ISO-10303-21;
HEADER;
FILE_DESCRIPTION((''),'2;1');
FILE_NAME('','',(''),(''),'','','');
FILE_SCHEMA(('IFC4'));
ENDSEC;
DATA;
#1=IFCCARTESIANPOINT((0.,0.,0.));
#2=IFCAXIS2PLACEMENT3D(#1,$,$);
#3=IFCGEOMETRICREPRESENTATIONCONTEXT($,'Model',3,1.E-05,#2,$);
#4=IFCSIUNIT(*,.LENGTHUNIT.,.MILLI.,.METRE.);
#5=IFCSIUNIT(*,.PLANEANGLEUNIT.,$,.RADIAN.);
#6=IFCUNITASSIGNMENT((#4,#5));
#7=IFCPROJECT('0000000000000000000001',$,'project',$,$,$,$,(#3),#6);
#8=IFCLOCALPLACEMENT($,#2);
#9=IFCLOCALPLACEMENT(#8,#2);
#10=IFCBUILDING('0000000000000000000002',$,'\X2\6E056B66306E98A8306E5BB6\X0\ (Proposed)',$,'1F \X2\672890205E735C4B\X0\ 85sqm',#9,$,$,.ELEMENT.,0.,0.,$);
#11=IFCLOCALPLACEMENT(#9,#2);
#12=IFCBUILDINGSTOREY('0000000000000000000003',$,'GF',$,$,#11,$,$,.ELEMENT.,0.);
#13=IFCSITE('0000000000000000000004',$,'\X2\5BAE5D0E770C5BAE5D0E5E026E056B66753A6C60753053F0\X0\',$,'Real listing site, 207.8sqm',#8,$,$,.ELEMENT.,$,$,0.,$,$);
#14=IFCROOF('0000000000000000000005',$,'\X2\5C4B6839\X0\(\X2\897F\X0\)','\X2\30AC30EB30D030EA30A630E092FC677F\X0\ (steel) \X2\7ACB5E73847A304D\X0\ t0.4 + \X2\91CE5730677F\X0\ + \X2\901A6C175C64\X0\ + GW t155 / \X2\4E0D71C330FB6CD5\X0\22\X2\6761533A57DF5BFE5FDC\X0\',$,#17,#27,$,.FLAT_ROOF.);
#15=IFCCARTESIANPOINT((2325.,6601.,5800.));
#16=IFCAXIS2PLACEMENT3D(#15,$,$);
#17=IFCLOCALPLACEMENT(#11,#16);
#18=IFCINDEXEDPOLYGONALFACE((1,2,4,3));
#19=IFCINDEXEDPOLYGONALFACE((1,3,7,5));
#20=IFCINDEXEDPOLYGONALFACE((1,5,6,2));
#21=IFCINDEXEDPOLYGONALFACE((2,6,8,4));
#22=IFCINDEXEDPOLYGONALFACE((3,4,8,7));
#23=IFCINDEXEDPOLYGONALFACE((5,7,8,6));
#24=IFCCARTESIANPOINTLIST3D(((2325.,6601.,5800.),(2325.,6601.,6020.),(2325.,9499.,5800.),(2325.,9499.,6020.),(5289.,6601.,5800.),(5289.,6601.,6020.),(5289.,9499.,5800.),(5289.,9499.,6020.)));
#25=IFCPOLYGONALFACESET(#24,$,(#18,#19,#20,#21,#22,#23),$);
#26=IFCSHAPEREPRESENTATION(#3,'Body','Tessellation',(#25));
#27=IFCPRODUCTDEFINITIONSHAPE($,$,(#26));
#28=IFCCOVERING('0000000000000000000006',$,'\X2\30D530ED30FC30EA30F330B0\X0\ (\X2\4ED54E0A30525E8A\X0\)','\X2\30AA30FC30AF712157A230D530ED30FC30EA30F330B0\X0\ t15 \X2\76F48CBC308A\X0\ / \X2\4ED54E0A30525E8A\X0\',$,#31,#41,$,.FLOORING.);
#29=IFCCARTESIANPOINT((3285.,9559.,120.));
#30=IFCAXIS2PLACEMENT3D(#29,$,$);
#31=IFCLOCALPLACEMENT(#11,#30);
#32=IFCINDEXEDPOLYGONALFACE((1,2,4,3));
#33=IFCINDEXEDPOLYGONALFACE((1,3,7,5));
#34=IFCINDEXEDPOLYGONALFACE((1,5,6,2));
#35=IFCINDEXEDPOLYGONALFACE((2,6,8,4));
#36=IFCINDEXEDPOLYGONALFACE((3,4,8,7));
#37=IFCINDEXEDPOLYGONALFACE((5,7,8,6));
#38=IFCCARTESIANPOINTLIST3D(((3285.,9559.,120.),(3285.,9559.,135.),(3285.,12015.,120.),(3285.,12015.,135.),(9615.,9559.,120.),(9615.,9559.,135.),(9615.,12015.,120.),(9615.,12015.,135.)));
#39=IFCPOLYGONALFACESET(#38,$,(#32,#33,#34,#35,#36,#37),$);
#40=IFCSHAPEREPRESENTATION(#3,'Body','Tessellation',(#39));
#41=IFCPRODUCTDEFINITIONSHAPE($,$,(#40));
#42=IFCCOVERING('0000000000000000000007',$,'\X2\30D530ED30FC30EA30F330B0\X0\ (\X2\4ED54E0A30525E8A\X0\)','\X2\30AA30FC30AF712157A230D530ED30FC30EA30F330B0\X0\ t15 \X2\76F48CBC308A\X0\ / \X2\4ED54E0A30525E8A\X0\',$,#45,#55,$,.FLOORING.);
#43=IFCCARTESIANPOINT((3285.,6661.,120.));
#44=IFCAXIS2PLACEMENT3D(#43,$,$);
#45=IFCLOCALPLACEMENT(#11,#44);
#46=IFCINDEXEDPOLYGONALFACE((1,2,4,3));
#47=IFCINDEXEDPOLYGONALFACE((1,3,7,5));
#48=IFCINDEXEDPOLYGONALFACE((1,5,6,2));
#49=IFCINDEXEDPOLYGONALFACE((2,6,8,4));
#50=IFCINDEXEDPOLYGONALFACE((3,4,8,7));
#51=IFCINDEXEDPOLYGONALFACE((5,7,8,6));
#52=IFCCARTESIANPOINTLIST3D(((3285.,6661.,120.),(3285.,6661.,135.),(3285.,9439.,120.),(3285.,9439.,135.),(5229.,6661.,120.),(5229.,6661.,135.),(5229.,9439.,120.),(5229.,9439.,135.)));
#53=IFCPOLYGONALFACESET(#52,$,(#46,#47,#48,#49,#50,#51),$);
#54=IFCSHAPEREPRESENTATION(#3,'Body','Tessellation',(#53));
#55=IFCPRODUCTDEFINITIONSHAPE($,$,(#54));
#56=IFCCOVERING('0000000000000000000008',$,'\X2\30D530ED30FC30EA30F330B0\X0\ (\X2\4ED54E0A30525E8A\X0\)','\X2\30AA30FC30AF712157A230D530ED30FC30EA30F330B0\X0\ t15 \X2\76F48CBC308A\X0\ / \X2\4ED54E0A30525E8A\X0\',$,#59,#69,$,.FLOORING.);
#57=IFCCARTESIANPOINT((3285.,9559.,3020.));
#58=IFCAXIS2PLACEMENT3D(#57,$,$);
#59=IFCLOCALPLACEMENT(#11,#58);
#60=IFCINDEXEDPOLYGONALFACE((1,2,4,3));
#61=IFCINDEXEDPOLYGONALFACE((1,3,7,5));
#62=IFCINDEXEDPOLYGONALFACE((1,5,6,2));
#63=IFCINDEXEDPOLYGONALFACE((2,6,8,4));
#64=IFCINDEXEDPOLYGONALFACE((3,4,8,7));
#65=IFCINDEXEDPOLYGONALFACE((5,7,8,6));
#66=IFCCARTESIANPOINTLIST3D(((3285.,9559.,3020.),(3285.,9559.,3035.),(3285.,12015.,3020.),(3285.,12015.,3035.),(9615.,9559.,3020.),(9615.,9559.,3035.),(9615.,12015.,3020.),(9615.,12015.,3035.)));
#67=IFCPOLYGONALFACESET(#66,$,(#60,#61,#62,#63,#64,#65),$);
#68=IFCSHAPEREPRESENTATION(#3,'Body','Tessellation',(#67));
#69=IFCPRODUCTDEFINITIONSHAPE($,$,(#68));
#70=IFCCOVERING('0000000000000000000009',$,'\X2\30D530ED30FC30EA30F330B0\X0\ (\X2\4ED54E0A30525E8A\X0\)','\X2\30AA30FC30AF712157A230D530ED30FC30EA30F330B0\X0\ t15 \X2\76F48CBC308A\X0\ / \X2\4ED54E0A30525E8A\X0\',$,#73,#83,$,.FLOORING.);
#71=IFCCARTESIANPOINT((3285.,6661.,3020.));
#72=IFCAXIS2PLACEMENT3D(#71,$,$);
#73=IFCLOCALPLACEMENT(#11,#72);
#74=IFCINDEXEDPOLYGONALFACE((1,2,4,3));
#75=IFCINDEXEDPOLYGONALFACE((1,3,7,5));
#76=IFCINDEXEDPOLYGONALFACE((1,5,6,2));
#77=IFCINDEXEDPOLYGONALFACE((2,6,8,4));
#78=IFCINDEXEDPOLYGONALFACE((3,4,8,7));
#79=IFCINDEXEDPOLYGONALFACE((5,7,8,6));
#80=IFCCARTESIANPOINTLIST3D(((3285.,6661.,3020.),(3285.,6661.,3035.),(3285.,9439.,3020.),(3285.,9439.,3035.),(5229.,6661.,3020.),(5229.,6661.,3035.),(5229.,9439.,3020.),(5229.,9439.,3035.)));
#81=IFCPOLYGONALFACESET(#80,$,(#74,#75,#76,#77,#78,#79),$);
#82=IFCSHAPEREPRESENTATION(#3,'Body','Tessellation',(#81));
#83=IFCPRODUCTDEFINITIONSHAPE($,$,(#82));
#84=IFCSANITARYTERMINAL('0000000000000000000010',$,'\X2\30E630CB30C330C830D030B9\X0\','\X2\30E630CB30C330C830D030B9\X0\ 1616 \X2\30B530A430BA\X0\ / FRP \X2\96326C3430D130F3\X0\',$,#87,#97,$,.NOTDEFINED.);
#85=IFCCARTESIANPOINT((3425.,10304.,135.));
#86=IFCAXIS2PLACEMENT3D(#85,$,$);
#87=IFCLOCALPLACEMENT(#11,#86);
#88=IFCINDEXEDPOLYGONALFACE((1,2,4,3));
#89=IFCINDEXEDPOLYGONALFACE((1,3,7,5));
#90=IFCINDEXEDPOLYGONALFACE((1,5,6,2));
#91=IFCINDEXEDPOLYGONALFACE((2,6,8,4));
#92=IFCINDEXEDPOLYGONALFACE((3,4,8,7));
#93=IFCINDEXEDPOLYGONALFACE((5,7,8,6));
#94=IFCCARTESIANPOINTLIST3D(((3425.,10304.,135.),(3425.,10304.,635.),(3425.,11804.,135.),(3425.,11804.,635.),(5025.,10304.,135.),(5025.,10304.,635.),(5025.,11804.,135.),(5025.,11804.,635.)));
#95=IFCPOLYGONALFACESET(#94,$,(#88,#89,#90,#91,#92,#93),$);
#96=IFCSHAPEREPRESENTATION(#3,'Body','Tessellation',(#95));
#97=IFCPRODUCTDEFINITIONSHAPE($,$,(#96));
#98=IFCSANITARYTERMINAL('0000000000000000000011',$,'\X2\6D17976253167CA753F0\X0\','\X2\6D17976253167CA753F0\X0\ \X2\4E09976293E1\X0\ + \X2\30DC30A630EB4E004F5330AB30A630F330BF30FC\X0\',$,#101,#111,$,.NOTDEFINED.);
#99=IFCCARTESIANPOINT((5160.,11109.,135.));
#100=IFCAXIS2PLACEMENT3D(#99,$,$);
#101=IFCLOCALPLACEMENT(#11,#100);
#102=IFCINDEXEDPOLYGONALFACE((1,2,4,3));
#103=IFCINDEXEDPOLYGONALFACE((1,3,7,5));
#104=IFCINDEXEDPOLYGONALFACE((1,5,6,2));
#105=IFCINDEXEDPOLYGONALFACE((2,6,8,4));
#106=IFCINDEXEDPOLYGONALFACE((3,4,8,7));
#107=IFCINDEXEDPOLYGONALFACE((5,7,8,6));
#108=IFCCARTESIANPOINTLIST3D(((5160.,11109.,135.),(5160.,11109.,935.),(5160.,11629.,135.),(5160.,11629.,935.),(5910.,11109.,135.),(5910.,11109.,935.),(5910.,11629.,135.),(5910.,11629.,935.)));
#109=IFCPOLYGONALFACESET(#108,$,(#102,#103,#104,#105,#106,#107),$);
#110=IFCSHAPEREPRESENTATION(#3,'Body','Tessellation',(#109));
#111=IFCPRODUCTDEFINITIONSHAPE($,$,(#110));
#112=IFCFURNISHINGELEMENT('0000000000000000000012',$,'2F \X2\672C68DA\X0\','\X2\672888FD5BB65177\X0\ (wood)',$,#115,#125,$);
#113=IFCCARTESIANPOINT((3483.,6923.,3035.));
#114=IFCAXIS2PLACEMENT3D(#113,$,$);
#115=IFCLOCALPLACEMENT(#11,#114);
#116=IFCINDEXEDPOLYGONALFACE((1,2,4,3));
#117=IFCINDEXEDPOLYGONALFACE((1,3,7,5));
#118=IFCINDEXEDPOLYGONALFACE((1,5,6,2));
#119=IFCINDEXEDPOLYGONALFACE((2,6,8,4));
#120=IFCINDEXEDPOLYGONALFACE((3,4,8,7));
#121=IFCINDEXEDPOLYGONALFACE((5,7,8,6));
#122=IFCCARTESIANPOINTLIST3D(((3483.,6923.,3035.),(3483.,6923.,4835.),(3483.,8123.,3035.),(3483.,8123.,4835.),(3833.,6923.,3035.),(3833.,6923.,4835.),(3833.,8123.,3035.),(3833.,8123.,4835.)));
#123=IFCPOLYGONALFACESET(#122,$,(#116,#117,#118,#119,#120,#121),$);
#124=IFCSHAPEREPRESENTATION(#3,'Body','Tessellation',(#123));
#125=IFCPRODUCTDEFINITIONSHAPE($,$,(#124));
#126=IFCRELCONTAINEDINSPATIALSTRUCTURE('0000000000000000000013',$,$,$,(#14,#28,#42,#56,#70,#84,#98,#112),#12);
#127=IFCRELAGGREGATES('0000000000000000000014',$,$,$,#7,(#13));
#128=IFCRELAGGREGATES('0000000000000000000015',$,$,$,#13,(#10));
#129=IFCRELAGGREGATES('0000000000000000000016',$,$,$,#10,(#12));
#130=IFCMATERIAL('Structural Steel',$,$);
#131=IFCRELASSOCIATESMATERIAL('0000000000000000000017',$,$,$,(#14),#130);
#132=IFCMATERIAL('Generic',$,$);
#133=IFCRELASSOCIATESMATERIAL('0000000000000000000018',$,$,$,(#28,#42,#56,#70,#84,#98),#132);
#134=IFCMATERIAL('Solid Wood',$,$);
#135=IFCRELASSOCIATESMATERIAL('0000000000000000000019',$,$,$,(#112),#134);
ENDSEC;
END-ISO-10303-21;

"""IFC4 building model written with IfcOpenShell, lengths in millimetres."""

from ifc_helpers import new_model, si_unit, frame, frame_2d, origin, place, context, project, spatial, rectangle, extrude, material, element, save


model = new_model("IFC4")

# Units and contexts
model_context = context("Model", 3, precision=1e-05, world=origin())
ifc_project = project(units=[si_unit("LENGTHUNIT", "METRE", prefix="MILLI"), si_unit("PLANEANGLEUNIT", "RADIAN")], contexts=[model_context])

# Site, building, storey
site_placement = place(None, origin())
site = spatial("IfcSite", under=ifc_project, at=site_placement, Name="宮崎県宮崎市清武町池田台", ObjectType="Real listing site, 207.8sqm", CompositionType="ELEMENT", RefElevation=0.0)
building_placement = place(site_placement, origin())
building = spatial("IfcBuilding", under=site, at=building_placement, Name="清武の風の家 (Proposed)", ObjectType="1F 木造平屋 85sqm", CompositionType="ELEMENT", ElevationOfRefHeight=0.0, ElevationOfTerrain=0.0)
storey_placement = place(building_placement, origin())
storey = spatial("IfcBuildingStorey", under=building, at=storey_placement, Name="GF", CompositionType="ELEMENT", Elevation=0.0)

# Shared definitions
ifc_material_1 = material(Name="Solid Wood")

# Roof
ifc_material_2 = material(Name="Structural Steel")
roof_placement = place(storey_placement, frame((2325.0, 6601.0, 5800.0)))
element("IfcRoof", 1, at=roof_placement, inside=storey, material=ifc_material_2, Name="屋根(西)", Description="ガルバリウム鋼板 (steel) 立平葺き t0.4 + 野地板 + 通気層 + GW t155 / 不燃・法22条区域対応", PredefinedType="FLAT_ROOF", context=model_context, shape_type="SweptSolid", body=[
    extrude(rectangle(XDim=2964.0, YDim=2898.0, at=frame_2d((1482.0, 1449.0))), frame((2325.0, 6601.0, 5800.0)), (0.0, 0.0, 1.0), 220.0),
])

# Coverings
ifc_material_3 = material(Name="Generic")
covering_1_placement = place(storey_placement, frame((3285.0, 9559.0, 120.0)))
element("IfcCovering", 2, at=covering_1_placement, inside=storey, material=ifc_material_3, Name="フローリング (仕上げ床)", Description="オーク無垢フローリング t15 直貼り / 仕上げ床", PredefinedType="FLOORING", context=model_context, shape_type="SweptSolid", body=[
    extrude(rectangle(XDim=6330.0, YDim=2456.0, at=frame_2d((3165.0, 1228.0))), frame((3285.0, 9559.0, 120.0)), (0.0, 0.0, 1.0), 15.0),
])
covering_2_placement = place(storey_placement, frame((3285.0, 6661.0, 120.0)))
element("IfcCovering", 3, at=covering_2_placement, inside=storey, material=ifc_material_3, Name="フローリング (仕上げ床)", Description="オーク無垢フローリング t15 直貼り / 仕上げ床", PredefinedType="FLOORING", context=model_context, shape_type="SweptSolid", body=[
    extrude(rectangle(XDim=1944.0, YDim=2778.0, at=frame_2d((972.0, 1389.0))), frame((3285.0, 6661.0, 120.0)), (0.0, 0.0, 1.0), 15.0),
])
covering_3_placement = place(storey_placement, frame((3285.0, 9559.0, 3020.0)))
element("IfcCovering", 4, at=covering_3_placement, inside=storey, material=ifc_material_3, Name="フローリング (仕上げ床)", Description="オーク無垢フローリング t15 直貼り / 仕上げ床", PredefinedType="FLOORING", context=model_context, shape_type="SweptSolid", body=[
    extrude(rectangle(XDim=6330.0, YDim=2456.0, at=frame_2d((3165.0, 1228.0))), frame((3285.0, 9559.0, 3020.0)), (0.0, 0.0, 1.0), 15.0),
])
covering_4_placement = place(storey_placement, frame((3285.0, 6661.0, 3020.0)))
element("IfcCovering", 5, at=covering_4_placement, inside=storey, material=ifc_material_3, Name="フローリング (仕上げ床)", Description="オーク無垢フローリング t15 直貼り / 仕上げ床", PredefinedType="FLOORING", context=model_context, shape_type="SweptSolid", body=[
    extrude(rectangle(XDim=1944.0, YDim=2778.0, at=frame_2d((972.0, 1389.0))), frame((3285.0, 6661.0, 3020.0)), (0.0, 0.0, 1.0), 15.0),
])

# Sanitary terminals
sanitary_terminal_1_placement = place(storey_placement, frame((3425.0, 10304.0, 135.0)))
element("IfcSanitaryTerminal", 6, at=sanitary_terminal_1_placement, inside=storey, material=ifc_material_3, Name="ユニットバス", Description="ユニットバス 1616 サイズ / FRP 防水パン", PredefinedType="NOTDEFINED", context=model_context, shape_type="SweptSolid", body=[
    extrude(rectangle(XDim=1600.0, YDim=1500.0, at=frame_2d((800.0, 750.0))), frame((3425.0, 10304.0, 135.0)), (0.0, 0.0, 1.0), 500.0),
])
sanitary_terminal_2_placement = place(storey_placement, frame((5160.0, 11109.0, 135.0)))
element("IfcSanitaryTerminal", 7, at=sanitary_terminal_2_placement, inside=storey, material=ifc_material_3, Name="洗面化粧台", Description="洗面化粧台 三面鏡 + ボウル一体カウンター", PredefinedType="NOTDEFINED", context=model_context, shape_type="SweptSolid", body=[
    extrude(rectangle(XDim=750.0, YDim=520.0, at=frame_2d((375.0, 260.0))), frame((5160.0, 11109.0, 135.0)), (0.0, 0.0, 1.0), 800.0),
])

# Furnishing element
furnishing_placement = place(storey_placement, frame((3483.0, 6923.0, 3035.0)))
element("IfcFurnishingElement", 8, at=furnishing_placement, inside=storey, material=ifc_material_1, Name="2F 本棚", Description="木製家具 (wood)", context=model_context, shape_type="SweptSolid", body=[
    extrude(rectangle(XDim=350.0, YDim=1200.0, at=frame_2d((175.0, 600.0))), frame((3483.0, 6923.0, 3035.0)), (0.0, 0.0, 1.0), 1800.0),
])

save(model, "model.ifc")
